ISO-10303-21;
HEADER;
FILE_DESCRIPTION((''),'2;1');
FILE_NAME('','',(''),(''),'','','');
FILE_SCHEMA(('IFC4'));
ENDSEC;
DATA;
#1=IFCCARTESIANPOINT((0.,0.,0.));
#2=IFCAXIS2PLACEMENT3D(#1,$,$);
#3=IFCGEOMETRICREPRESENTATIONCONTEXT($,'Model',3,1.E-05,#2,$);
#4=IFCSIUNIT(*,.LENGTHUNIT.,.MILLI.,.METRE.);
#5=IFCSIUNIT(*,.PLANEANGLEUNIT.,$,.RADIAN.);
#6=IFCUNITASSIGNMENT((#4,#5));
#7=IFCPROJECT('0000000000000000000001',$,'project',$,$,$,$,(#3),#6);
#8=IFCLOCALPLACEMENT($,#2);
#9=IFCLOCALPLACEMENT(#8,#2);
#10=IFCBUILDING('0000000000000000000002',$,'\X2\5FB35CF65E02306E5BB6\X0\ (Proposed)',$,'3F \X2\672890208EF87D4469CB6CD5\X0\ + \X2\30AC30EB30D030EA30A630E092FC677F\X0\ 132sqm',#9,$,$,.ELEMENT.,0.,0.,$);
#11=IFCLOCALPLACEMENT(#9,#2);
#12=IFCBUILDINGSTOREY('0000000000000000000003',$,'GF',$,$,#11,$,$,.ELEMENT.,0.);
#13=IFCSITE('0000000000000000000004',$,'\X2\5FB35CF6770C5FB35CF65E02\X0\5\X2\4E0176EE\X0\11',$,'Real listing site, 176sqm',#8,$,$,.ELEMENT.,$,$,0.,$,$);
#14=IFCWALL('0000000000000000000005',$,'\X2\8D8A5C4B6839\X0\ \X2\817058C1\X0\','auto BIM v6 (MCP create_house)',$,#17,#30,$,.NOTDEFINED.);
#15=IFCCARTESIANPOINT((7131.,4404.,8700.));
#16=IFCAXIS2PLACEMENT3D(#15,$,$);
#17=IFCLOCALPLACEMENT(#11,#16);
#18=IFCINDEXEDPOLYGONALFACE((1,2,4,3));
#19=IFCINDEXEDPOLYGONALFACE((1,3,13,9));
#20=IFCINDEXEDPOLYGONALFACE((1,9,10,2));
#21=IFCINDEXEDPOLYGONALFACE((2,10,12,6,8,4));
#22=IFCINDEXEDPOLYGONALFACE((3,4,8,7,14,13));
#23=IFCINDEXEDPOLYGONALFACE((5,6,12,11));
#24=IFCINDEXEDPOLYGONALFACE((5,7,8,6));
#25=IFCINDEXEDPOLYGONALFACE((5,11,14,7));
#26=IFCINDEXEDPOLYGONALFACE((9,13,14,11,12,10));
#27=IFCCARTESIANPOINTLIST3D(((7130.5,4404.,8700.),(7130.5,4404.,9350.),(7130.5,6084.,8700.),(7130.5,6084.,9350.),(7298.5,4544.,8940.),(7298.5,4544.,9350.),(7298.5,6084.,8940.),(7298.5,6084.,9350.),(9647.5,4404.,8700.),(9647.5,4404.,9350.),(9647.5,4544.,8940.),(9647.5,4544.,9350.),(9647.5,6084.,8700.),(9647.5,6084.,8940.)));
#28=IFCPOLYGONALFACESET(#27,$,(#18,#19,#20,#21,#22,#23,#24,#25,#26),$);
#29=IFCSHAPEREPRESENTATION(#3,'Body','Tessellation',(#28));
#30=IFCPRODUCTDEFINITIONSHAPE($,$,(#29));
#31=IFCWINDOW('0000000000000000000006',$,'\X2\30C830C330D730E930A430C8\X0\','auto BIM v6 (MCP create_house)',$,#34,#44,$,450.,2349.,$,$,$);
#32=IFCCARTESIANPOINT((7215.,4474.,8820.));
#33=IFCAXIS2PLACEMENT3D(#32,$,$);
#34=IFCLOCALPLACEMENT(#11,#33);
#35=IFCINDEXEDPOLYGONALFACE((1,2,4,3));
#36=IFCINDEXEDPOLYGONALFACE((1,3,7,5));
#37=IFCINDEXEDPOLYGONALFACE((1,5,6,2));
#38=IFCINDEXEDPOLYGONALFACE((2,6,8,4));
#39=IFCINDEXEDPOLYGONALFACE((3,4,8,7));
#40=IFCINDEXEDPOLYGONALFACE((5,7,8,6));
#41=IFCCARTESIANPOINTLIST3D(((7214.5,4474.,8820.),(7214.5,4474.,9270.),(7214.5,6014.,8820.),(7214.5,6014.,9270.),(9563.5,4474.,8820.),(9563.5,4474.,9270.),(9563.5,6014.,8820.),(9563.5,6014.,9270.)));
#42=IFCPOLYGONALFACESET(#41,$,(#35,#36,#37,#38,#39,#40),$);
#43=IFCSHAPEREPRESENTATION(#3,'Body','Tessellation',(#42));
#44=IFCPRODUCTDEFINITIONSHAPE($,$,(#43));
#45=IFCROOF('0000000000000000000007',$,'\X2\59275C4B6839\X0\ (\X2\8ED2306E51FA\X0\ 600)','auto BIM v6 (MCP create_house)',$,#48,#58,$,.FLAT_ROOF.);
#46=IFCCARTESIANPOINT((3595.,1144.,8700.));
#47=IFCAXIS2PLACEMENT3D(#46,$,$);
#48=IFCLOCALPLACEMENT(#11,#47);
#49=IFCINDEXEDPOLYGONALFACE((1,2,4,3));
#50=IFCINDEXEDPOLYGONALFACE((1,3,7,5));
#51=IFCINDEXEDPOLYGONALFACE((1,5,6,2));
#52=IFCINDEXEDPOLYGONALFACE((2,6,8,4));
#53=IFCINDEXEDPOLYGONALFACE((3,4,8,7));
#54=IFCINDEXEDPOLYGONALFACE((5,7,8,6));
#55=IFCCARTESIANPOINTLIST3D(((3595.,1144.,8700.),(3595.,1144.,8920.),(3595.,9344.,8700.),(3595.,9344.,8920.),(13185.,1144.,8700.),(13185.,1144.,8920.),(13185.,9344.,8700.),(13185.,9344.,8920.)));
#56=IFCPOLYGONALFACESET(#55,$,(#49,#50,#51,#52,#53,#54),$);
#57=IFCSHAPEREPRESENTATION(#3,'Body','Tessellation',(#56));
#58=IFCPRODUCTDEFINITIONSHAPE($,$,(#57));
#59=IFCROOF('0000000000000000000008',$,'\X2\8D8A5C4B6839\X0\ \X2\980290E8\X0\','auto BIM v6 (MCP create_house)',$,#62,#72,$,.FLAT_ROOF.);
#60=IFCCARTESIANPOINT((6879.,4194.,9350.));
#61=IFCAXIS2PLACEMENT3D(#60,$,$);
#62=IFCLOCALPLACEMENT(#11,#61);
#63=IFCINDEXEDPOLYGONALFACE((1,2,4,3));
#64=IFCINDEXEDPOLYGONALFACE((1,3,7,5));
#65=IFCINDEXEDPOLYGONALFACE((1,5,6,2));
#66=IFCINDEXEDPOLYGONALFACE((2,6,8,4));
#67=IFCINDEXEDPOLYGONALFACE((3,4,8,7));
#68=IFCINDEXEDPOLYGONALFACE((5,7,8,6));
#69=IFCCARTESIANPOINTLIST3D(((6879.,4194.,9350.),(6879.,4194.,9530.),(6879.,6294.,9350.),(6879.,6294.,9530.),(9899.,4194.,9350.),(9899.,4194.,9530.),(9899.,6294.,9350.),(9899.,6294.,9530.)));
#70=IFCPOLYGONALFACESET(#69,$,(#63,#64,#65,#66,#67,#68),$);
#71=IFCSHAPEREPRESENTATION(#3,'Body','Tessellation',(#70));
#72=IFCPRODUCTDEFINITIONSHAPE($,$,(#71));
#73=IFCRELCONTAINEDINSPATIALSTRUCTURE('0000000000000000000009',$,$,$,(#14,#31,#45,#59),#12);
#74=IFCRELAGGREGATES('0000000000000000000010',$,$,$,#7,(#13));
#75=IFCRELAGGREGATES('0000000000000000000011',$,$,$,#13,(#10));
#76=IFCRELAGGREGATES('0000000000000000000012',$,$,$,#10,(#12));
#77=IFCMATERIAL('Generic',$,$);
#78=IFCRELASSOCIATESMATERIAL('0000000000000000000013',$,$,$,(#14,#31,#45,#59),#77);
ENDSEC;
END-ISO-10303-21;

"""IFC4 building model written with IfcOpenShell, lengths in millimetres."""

from ifc_helpers import new_model, si_unit, frame, frame_2d, origin, place, context, project, spatial, rectangle, extrude, material, element, fill, save


model = new_model("IFC4")

# Units and contexts
model_context = context("Model", 3, precision=1e-05, world=origin())
ifc_project = project(units=[si_unit("LENGTHUNIT", "METRE", prefix="MILLI"), si_unit("PLANEANGLEUNIT", "RADIAN")], contexts=[model_context])

# Site, building, storey
site_placement = place(None, origin())
site = spatial("IfcSite", under=ifc_project, at=site_placement, Name="徳島県徳島市5丁目11", ObjectType="Real listing site, 176sqm", CompositionType="ELEMENT", RefElevation=0.0)
building_placement = place(site_placement, origin())
building = spatial("IfcBuilding", under=site, at=building_placement, Name="徳島市の家 (Proposed)", ObjectType="3F 木造軸組構法 + ガルバリウム鋼板 132sqm", CompositionType="ELEMENT", ElevationOfRefHeight=0.0, ElevationOfTerrain=0.0)
storey_placement = place(building_placement, origin())
storey = spatial("IfcBuildingStorey", under=building, at=storey_placement, Name="GF", CompositionType="ELEMENT", Elevation=0.0)

# Shared definitions
ifc_material = material(Name="Generic")

# Wall, opening, window
wall_1_placement = place(storey_placement, frame((7131.0, 4404.0, 8700.0)))
wall_1 = element("IfcWall", 1, at=wall_1_placement, inside=storey, material=ifc_material, Name="越屋根 腰壁", Description="auto BIM v6 (MCP create_house)", PredefinedType="NOTDEFINED", context=model_context, shape_type="SweptSolid", body=[
    extrude(rectangle(XDim=2517.0, YDim=1680.0, at=frame_2d((1258.0, 840.0))), frame((7131.0, 4404.0, 8700.0)), (0.0, 0.0, 1.0), 650.0),
])
opening_1_placement = place(storey_placement, frame((7215.0, 4474.0, 8820.0)))
opening_1 = element("IfcOpeningElement", 2, at=opening_1_placement, cuts=wall_1, PredefinedType="NOTDEFINED", context=model_context, shape_type="SweptSolid", body=[
    extrude(rectangle(XDim=2349.0, YDim=1540.0, at=frame_2d((1174.0, 770.0))), frame((7215.0, 4474.0, 8820.0)), (0.0, 0.0, 1.0), 450.0),
])
window_1_placement = place(storey_placement, frame((7215.0, 4474.0, 8820.0)))
window_1 = element("IfcWindow", 3, at=window_1_placement, inside=storey, material=ifc_material, Name="トップライト", Description="auto BIM v6 (MCP create_house)", OverallHeight=450.0, OverallWidth=2349.0, context=model_context, shape_type="SweptSolid", body=[
    extrude(rectangle(XDim=2349.0, YDim=1540.0, at=frame_2d((1174.0, 770.0))), frame((7215.0, 4474.0, 8820.0)), (0.0, 0.0, 1.0), 450.0),
])
fill(opening_1, window_1)

# Roofs
roof_1_placement = place(storey_placement, frame((3595.0, 1144.0, 8700.0)))
element("IfcRoof", 4, at=roof_1_placement, inside=storey, material=ifc_material, Name="大屋根 (軒の出 600)", Description="auto BIM v6 (MCP create_house)", PredefinedType="FLAT_ROOF", context=model_context, shape_type="SweptSolid", body=[
    extrude(rectangle(XDim=9590.0, YDim=8200.0, at=frame_2d((4795.0, 4100.0))), frame((3595.0, 1144.0, 8700.0)), (0.0, 0.0, 1.0), 220.0),
])
roof_2_placement = place(storey_placement, frame((6879.0, 4194.0, 9350.0)))
element("IfcRoof", 5, at=roof_2_placement, inside=storey, material=ifc_material, Name="越屋根 頂部", Description="auto BIM v6 (MCP create_house)", PredefinedType="FLAT_ROOF", context=model_context, shape_type="SweptSolid", body=[
    extrude(rectangle(XDim=3020.0, YDim=2100.0, at=frame_2d((1510.0, 1050.0))), frame((6879.0, 4194.0, 9350.0)), (0.0, 0.0, 1.0), 180.0),
])

save(model, "model.ifc")
